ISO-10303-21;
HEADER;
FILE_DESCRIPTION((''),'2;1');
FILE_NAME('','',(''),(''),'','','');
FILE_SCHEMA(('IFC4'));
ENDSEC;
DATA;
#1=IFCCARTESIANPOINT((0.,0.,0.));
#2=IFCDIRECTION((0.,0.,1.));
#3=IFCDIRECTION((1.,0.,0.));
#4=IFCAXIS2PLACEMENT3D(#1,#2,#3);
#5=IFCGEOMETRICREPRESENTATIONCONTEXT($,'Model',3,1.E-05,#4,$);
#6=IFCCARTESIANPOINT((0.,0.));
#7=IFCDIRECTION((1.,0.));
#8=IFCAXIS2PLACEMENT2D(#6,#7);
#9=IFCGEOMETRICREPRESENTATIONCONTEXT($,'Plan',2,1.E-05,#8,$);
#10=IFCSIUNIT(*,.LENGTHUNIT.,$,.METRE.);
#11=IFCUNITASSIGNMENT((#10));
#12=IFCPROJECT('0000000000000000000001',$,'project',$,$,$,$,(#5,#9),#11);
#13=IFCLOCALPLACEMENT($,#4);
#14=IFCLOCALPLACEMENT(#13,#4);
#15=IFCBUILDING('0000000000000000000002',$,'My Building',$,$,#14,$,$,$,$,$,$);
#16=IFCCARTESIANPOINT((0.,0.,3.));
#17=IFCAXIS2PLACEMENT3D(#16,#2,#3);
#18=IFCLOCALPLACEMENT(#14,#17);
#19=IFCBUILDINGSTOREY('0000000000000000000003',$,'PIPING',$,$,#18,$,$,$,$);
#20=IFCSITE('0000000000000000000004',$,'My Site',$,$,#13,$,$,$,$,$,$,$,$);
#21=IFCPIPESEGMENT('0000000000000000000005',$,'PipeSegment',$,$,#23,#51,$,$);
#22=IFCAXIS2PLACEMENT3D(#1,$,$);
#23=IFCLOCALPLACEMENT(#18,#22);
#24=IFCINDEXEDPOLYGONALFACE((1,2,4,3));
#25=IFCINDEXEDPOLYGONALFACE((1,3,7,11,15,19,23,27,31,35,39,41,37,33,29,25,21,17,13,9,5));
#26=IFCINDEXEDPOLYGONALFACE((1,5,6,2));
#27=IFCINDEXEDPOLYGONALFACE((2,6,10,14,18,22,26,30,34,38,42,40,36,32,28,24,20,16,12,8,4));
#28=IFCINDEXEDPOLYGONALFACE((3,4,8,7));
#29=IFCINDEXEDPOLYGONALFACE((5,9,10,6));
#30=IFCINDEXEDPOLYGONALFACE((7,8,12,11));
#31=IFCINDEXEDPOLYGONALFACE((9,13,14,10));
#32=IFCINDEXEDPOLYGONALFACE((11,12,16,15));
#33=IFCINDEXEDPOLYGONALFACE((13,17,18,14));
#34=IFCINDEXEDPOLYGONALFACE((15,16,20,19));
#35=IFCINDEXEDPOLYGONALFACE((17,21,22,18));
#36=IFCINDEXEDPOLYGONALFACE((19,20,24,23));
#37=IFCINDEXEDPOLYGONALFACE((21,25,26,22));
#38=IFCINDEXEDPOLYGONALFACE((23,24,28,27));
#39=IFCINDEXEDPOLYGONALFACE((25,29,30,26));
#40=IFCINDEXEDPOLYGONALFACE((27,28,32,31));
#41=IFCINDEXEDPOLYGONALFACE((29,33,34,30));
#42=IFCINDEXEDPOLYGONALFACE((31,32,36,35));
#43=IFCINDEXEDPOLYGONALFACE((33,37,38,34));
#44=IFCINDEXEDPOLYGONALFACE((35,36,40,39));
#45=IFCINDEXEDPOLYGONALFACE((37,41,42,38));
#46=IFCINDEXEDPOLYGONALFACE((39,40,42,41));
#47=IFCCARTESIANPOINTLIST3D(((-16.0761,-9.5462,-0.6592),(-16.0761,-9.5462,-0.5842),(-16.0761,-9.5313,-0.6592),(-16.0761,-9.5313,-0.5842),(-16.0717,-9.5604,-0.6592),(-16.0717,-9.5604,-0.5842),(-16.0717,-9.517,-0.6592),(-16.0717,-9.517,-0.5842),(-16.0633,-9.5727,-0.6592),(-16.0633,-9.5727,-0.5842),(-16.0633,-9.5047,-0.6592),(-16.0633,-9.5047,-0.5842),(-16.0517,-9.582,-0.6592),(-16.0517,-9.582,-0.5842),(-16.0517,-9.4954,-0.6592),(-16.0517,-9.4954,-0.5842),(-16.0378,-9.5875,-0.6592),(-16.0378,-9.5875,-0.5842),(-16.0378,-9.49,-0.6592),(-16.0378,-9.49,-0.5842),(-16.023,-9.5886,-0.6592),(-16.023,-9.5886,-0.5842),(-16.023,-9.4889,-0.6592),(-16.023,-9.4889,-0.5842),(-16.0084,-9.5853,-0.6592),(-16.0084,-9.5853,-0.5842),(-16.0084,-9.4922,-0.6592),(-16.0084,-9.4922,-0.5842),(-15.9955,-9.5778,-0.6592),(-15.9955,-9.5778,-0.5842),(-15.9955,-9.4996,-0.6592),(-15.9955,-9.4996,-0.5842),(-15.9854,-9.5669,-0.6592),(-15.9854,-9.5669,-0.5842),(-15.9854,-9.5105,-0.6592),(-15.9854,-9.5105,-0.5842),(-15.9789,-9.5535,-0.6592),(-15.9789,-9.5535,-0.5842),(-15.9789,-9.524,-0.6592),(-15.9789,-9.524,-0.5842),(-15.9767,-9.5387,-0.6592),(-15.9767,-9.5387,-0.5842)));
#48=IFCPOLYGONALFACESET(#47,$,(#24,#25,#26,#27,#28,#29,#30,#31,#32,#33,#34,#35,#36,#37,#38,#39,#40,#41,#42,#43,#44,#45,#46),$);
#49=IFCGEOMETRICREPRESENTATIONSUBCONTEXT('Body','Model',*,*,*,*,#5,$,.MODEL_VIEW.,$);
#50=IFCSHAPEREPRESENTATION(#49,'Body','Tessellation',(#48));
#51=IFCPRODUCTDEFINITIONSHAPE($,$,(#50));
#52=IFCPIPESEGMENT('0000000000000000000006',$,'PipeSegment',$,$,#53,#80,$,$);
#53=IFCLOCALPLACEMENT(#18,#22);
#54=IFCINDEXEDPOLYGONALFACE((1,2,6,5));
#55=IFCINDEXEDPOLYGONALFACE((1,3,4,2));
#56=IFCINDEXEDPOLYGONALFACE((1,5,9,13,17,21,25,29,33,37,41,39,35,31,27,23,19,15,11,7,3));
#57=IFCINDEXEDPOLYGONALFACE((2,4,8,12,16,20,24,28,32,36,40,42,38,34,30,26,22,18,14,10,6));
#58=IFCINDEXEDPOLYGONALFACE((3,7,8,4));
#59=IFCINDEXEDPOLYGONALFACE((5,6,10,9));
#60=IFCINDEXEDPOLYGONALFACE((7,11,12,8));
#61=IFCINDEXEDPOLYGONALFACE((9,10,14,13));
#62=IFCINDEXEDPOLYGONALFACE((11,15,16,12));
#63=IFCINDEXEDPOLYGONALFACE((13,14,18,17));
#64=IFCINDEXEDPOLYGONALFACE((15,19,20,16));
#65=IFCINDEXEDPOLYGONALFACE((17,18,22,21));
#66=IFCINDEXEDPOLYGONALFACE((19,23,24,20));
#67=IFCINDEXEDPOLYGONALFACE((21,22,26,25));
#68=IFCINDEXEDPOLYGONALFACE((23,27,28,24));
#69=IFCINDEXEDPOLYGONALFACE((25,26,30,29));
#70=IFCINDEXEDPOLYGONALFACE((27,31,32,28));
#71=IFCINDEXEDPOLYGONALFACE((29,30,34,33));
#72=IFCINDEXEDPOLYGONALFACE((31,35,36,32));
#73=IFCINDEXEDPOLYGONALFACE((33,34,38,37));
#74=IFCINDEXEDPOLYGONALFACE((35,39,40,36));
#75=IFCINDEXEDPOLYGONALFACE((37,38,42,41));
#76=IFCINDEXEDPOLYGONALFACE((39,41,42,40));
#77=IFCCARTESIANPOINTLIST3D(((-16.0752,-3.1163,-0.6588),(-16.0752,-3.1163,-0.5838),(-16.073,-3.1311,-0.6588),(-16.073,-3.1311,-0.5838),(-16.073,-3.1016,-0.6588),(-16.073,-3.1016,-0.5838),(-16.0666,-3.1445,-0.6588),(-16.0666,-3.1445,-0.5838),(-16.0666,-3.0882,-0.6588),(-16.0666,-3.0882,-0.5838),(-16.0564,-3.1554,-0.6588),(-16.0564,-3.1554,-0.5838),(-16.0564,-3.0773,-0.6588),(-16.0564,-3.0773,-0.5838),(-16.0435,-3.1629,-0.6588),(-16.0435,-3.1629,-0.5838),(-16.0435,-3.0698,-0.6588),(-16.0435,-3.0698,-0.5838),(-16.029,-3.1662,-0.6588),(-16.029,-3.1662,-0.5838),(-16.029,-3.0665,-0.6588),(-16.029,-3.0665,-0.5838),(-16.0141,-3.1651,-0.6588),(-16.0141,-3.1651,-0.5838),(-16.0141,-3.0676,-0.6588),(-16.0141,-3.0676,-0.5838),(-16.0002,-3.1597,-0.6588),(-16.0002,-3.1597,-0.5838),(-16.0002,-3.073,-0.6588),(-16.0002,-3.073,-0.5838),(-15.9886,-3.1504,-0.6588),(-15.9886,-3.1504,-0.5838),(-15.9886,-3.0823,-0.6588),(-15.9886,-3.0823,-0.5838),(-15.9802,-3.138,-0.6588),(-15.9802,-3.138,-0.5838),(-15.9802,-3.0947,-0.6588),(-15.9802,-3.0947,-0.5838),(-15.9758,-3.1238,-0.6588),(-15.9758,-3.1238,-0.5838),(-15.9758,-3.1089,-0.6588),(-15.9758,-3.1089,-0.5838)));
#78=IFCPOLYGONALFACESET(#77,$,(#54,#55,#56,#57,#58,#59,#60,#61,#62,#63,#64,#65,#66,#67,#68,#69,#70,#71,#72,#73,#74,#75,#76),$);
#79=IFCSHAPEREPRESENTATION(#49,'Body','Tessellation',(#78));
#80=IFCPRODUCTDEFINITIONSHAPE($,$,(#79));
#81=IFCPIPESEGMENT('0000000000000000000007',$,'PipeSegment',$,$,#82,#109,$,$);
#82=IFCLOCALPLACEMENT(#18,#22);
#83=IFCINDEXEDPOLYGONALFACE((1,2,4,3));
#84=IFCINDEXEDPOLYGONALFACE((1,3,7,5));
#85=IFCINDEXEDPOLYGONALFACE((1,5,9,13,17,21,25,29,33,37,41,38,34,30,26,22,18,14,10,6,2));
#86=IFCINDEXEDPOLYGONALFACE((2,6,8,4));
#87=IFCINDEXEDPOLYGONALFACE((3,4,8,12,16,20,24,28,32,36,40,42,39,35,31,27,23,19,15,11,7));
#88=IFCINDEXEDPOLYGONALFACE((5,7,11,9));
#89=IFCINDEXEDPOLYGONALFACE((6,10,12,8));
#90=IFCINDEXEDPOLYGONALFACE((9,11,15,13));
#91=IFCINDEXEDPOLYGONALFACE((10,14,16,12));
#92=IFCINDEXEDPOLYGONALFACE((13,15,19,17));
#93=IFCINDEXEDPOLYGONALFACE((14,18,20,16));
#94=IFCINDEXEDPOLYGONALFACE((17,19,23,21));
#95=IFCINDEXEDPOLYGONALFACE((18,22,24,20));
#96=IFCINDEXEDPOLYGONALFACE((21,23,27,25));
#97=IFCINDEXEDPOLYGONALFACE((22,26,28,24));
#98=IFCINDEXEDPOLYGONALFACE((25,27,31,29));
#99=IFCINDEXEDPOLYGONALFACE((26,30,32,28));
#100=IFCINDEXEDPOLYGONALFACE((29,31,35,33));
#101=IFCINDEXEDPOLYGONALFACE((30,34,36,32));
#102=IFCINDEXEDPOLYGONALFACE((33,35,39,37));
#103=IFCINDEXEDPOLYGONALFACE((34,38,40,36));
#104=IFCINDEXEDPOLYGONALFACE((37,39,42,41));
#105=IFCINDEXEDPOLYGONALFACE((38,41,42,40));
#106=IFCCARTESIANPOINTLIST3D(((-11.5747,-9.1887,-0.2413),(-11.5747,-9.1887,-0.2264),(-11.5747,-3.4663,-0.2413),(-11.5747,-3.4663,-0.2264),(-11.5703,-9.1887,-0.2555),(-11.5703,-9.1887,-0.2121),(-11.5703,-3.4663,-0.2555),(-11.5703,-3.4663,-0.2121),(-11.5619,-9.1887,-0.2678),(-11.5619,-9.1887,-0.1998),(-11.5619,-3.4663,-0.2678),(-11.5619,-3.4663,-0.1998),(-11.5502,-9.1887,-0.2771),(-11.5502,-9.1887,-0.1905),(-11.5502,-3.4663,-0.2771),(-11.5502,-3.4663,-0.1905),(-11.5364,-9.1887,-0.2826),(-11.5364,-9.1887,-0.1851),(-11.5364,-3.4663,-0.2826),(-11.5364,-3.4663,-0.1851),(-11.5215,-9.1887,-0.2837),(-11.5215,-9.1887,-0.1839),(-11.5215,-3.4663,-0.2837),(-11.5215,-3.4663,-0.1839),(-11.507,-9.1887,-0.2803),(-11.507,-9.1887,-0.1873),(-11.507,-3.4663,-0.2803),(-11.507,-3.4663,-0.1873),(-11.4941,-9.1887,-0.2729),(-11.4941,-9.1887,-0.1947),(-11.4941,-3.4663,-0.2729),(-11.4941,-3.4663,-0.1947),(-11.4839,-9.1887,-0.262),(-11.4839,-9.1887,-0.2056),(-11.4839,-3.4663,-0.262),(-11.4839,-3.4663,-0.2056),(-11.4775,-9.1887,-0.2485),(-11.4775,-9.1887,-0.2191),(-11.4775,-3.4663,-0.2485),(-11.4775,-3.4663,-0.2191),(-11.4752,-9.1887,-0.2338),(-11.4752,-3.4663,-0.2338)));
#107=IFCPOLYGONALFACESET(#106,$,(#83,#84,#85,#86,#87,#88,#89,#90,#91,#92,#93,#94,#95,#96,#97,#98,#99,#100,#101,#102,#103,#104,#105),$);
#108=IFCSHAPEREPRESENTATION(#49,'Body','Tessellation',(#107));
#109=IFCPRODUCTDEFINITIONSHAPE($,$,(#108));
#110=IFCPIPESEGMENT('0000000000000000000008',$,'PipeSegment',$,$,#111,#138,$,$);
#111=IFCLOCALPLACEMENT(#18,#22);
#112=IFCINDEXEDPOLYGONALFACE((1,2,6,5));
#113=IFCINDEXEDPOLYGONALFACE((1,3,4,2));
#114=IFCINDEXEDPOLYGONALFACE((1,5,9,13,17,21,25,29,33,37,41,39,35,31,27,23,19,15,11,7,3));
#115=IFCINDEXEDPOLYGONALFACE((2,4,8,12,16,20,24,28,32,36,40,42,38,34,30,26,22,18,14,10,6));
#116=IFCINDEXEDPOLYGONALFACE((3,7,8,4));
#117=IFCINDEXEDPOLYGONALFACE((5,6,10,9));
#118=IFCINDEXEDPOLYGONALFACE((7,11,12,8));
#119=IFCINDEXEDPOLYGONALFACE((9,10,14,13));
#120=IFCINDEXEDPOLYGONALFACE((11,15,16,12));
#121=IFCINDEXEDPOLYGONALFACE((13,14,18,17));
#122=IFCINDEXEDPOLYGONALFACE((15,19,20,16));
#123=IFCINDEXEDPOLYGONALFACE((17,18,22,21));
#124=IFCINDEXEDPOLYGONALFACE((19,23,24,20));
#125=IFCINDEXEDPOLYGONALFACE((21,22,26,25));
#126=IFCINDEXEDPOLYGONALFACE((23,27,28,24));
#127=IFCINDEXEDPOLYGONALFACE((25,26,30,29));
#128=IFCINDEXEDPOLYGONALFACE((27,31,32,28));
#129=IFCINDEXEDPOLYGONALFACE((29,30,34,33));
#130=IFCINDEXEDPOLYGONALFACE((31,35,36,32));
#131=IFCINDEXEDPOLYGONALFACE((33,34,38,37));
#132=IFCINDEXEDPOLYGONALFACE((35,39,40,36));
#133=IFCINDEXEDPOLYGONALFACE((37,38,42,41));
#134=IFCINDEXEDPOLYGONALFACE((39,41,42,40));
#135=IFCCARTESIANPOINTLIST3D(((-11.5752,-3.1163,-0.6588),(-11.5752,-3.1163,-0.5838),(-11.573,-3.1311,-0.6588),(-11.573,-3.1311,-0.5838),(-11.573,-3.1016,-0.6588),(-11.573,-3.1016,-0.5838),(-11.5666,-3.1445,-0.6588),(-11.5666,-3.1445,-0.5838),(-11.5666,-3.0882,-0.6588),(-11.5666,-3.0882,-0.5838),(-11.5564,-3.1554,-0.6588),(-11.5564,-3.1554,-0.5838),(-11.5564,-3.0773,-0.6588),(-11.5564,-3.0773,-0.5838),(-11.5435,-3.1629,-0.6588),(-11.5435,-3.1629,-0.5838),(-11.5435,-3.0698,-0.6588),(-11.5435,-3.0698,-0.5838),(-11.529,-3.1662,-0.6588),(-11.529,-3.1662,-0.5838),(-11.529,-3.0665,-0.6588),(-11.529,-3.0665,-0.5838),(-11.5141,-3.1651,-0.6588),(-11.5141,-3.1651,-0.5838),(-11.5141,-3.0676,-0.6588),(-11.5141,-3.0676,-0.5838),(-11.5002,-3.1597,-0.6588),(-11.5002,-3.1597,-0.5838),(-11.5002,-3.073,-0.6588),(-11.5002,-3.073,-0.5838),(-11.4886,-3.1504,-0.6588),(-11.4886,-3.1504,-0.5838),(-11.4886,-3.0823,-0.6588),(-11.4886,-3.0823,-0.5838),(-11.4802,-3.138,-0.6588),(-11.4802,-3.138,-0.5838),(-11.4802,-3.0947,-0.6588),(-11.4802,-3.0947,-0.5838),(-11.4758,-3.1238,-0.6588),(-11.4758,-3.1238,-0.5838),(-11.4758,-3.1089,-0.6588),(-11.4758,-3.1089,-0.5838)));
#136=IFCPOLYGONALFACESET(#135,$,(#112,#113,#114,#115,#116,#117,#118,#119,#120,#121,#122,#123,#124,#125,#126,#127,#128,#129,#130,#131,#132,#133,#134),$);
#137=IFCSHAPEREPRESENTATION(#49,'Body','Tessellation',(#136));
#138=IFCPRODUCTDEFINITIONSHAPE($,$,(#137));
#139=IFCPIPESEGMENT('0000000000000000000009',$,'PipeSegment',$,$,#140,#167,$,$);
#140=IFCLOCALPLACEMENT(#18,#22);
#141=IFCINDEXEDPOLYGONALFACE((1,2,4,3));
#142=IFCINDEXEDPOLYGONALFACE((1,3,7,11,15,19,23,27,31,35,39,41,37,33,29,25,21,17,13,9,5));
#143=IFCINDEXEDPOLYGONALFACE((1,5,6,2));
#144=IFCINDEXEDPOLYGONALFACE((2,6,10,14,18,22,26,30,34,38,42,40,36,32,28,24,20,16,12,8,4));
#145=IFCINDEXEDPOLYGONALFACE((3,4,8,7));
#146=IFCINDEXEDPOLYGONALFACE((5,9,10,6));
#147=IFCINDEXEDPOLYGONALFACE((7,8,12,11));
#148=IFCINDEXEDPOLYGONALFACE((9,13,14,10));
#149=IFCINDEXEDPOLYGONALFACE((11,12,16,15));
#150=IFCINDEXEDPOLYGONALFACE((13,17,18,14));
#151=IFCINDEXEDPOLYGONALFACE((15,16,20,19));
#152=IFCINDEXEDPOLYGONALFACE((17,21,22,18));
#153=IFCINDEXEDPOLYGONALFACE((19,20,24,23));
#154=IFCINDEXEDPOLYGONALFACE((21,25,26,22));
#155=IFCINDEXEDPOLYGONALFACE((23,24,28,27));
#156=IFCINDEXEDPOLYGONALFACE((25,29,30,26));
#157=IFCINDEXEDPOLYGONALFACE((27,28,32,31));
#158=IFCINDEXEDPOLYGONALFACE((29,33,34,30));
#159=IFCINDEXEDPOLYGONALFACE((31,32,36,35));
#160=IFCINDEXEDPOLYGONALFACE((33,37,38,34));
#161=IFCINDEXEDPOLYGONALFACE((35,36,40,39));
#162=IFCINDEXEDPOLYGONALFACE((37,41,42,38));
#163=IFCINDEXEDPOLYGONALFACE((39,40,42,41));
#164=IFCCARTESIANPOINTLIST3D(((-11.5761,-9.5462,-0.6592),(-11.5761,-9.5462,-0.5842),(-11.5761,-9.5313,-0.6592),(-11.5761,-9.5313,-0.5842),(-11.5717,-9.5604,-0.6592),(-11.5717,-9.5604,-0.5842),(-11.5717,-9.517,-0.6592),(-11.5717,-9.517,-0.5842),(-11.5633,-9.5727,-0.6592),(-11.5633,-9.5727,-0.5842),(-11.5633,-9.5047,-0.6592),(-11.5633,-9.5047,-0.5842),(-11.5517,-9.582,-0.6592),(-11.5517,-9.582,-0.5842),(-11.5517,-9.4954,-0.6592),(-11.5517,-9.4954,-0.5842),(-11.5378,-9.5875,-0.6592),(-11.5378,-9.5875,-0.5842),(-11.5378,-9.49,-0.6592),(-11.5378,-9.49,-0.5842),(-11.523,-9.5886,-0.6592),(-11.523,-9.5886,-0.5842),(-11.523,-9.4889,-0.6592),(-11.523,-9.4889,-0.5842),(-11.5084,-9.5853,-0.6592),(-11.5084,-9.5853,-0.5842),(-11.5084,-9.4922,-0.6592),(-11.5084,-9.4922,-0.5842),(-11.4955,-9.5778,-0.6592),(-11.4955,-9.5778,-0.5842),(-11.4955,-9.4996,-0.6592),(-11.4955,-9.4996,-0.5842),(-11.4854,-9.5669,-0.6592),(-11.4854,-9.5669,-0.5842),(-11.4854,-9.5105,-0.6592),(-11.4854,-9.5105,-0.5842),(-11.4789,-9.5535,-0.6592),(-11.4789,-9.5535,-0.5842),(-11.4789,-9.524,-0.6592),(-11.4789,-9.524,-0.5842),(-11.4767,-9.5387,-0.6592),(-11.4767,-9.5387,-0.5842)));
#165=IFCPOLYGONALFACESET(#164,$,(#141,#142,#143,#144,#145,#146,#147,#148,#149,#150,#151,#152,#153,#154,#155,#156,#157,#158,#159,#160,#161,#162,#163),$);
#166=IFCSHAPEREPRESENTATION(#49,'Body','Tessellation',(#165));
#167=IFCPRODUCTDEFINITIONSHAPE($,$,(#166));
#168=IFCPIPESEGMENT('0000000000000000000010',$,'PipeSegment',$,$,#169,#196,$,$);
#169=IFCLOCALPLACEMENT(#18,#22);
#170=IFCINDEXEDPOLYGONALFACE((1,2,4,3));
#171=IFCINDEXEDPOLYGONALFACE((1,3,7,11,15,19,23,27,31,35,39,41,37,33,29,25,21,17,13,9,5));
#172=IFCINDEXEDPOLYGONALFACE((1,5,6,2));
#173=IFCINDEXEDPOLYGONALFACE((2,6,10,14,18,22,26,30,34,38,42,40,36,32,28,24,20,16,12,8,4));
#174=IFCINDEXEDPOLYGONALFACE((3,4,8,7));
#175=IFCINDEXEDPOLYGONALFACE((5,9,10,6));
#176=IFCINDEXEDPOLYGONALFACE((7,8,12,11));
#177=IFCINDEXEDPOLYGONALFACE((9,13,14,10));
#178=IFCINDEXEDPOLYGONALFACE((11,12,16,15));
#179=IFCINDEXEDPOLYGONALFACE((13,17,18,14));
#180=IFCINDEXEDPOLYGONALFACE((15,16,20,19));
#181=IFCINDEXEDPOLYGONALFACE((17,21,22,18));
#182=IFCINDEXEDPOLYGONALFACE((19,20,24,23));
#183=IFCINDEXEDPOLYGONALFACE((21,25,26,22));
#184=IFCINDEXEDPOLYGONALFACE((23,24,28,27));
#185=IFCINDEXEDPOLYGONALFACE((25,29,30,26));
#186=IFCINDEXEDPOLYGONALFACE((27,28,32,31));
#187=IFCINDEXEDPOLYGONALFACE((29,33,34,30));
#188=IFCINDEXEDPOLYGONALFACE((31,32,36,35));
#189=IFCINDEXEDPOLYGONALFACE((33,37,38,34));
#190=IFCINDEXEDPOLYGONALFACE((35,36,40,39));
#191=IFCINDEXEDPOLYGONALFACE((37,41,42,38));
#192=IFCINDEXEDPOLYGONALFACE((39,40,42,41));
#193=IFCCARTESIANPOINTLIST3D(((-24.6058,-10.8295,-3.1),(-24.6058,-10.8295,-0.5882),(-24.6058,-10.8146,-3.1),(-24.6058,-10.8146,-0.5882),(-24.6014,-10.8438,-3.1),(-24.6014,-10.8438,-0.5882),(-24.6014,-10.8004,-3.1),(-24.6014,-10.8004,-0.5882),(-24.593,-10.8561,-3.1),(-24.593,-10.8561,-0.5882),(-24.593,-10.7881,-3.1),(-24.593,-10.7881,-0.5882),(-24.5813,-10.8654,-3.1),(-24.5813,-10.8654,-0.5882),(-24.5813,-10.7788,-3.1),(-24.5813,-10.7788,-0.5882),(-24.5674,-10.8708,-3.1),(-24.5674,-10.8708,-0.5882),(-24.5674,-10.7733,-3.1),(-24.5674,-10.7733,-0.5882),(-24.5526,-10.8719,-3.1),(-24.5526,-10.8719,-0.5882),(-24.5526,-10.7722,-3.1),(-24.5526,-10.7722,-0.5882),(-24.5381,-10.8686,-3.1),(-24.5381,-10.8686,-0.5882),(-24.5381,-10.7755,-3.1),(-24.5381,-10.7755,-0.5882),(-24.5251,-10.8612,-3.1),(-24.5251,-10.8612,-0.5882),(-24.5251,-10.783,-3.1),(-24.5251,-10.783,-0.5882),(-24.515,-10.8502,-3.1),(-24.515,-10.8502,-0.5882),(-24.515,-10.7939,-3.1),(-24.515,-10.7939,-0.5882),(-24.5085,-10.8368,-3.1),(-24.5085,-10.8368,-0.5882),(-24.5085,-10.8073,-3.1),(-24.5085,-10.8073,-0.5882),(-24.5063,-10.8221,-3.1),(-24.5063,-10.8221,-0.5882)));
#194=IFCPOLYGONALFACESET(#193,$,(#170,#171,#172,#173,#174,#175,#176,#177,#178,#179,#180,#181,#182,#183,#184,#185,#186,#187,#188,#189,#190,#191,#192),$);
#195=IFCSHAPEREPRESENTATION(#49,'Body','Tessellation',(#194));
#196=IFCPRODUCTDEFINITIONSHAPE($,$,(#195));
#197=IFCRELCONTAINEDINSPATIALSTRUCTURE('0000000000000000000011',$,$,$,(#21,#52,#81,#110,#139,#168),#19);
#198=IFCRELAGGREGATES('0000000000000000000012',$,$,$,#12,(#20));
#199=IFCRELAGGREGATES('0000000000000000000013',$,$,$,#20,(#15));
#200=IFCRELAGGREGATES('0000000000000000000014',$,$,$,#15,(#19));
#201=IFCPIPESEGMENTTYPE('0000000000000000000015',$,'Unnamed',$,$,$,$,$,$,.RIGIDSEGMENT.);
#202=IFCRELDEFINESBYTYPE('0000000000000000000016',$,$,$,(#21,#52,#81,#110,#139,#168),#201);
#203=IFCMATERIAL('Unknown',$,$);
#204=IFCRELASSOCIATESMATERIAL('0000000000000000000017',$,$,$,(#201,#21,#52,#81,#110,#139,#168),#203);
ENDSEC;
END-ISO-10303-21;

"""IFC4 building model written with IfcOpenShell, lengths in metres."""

from ifc_helpers import new_model, si_unit, frame, origin_with_axes, origin_2d_with_axis, place, context, subcontext, project, spatial, circle, extrude, material, material_profile, profile_set, profile_usage, type_object, element, save


model = new_model("IFC4")

# Units and contexts
model_context = context("Model", 3, precision=1e-05, world=origin_with_axes())
plan_context = context("Plan", 2, precision=1e-05, world=origin_2d_with_axis())
body_context = subcontext(model_context, "Body", "Model", "MODEL_VIEW")
ifc_project = project(units=[si_unit("LENGTHUNIT", "METRE")], contexts=[model_context, plan_context])

# Site, building, storey
site_placement = place(None, origin_with_axes())
site = spatial("IfcSite", under=ifc_project, at=site_placement, Name="My Site")
building_placement = place(site_placement, origin_with_axes())
building = spatial("IfcBuilding", under=site, at=building_placement, Name="My Building")
storey_placement = place(building_placement, frame((0.0, 0.0, 3.0), z_axis=(0.0, 0.0, 1.0), x_axis=(1.0, 0.0, 0.0)))
storey = spatial("IfcBuildingStorey", under=building, at=storey_placement, Name="PIPING")

# Pipe segments
ifc_material = material(Name="Unknown")
ifc_material_profile = material_profile(ifc_material, circle(Radius=0.05))
ifc_profile_set = profile_set([ifc_material_profile])
pipe_segment_type = type_object("IfcPipeSegmentType", Name="Unnamed", PredefinedType="RIGIDSEGMENT", material=ifc_profile_set)
ifc_profile_usage_1 = profile_usage(ifc_profile_set, cardinal=5)
pipe_segment_1_placement = place(storey_placement, frame((-16.0267, -9.5387, -0.5842), z_axis=(0.0, 0.0, -1.0), x_axis=(1.0, 0.0, 0.0)))
element("IfcPipeSegment", 1, at=pipe_segment_1_placement, inside=storey, type_object=pipe_segment_type, material=ifc_profile_usage_1, Name="PipeSegment", context=body_context, shape_type="SweptSolid", body=[
    extrude(circle(Radius=0.05), origin_with_axes(), (0.0, 0.0, 1.0), 0.075),
])
ifc_profile_usage_2 = profile_usage(ifc_profile_set, cardinal=5)
pipe_segment_2_placement = place(storey_placement, frame((-16.0252, -3.1163, -0.5838), z_axis=(0.0, 0.0, -1.0), x_axis=(-1.0, 0.0, 0.0)))
element("IfcPipeSegment", 2, at=pipe_segment_2_placement, inside=storey, type_object=pipe_segment_type, material=ifc_profile_usage_2, Name="PipeSegment", context=body_context, shape_type="SweptSolid", body=[
    extrude(circle(Radius=0.05), origin_with_axes(), (0.0, 0.0, 1.0), 0.075),
])
ifc_profile_usage_3 = profile_usage(ifc_profile_set, cardinal=5)
pipe_segment_3_placement = place(storey_placement, frame((-11.5252, -3.4663, -0.2338), z_axis=(0.0, -1.0, 0.0), x_axis=(1.0, 0.0, 0.0)))
element("IfcPipeSegment", 3, at=pipe_segment_3_placement, inside=storey, type_object=pipe_segment_type, material=ifc_profile_usage_3, Name="PipeSegment", context=body_context, shape_type="SweptSolid", body=[
    extrude(circle(Radius=0.05), origin_with_axes(), (0.0, 0.0, 1.0), 5.7224),
])
ifc_profile_usage_4 = profile_usage(ifc_profile_set, cardinal=5)
pipe_segment_4_placement = place(storey_placement, frame((-11.5252, -3.1163, -0.5838), z_axis=(0.0, 0.0, -1.0), x_axis=(-1.0, 0.0, 0.0)))
element("IfcPipeSegment", 4, at=pipe_segment_4_placement, inside=storey, type_object=pipe_segment_type, material=ifc_profile_usage_4, Name="PipeSegment", context=body_context, shape_type="SweptSolid", body=[
    extrude(circle(Radius=0.05), origin_with_axes(), (0.0, 0.0, 1.0), 0.075),
])
ifc_profile_usage_5 = profile_usage(ifc_profile_set, cardinal=5)
pipe_segment_5_placement = place(storey_placement, frame((-11.5267, -9.5387, -0.5842), z_axis=(0.0, 0.0, -1.0), x_axis=(1.0, 0.0, 0.0)))
element("IfcPipeSegment", 5, at=pipe_segment_5_placement, inside=storey, type_object=pipe_segment_type, material=ifc_profile_usage_5, Name="PipeSegment", context=body_context, shape_type="SweptSolid", body=[
    extrude(circle(Radius=0.05), origin_with_axes(), (0.0, 0.0, 1.0), 0.075),
])
ifc_profile_usage_6 = profile_usage(ifc_profile_set, cardinal=5)
pipe_segment_6_placement = place(storey_placement, frame((-24.5563, -10.8221, -0.5882), z_axis=(0.0, 0.0, -1.0), x_axis=(1.0, 0.0, 0.0)))
element("IfcPipeSegment", 6, at=pipe_segment_6_placement, inside=storey, type_object=pipe_segment_type, material=ifc_profile_usage_6, Name="PipeSegment", context=body_context, shape_type="SweptSolid", body=[
    extrude(circle(Radius=0.05), origin_with_axes(), (0.0, 0.0, 1.0), 2.5118),
])

save(model, "model.ifc")
